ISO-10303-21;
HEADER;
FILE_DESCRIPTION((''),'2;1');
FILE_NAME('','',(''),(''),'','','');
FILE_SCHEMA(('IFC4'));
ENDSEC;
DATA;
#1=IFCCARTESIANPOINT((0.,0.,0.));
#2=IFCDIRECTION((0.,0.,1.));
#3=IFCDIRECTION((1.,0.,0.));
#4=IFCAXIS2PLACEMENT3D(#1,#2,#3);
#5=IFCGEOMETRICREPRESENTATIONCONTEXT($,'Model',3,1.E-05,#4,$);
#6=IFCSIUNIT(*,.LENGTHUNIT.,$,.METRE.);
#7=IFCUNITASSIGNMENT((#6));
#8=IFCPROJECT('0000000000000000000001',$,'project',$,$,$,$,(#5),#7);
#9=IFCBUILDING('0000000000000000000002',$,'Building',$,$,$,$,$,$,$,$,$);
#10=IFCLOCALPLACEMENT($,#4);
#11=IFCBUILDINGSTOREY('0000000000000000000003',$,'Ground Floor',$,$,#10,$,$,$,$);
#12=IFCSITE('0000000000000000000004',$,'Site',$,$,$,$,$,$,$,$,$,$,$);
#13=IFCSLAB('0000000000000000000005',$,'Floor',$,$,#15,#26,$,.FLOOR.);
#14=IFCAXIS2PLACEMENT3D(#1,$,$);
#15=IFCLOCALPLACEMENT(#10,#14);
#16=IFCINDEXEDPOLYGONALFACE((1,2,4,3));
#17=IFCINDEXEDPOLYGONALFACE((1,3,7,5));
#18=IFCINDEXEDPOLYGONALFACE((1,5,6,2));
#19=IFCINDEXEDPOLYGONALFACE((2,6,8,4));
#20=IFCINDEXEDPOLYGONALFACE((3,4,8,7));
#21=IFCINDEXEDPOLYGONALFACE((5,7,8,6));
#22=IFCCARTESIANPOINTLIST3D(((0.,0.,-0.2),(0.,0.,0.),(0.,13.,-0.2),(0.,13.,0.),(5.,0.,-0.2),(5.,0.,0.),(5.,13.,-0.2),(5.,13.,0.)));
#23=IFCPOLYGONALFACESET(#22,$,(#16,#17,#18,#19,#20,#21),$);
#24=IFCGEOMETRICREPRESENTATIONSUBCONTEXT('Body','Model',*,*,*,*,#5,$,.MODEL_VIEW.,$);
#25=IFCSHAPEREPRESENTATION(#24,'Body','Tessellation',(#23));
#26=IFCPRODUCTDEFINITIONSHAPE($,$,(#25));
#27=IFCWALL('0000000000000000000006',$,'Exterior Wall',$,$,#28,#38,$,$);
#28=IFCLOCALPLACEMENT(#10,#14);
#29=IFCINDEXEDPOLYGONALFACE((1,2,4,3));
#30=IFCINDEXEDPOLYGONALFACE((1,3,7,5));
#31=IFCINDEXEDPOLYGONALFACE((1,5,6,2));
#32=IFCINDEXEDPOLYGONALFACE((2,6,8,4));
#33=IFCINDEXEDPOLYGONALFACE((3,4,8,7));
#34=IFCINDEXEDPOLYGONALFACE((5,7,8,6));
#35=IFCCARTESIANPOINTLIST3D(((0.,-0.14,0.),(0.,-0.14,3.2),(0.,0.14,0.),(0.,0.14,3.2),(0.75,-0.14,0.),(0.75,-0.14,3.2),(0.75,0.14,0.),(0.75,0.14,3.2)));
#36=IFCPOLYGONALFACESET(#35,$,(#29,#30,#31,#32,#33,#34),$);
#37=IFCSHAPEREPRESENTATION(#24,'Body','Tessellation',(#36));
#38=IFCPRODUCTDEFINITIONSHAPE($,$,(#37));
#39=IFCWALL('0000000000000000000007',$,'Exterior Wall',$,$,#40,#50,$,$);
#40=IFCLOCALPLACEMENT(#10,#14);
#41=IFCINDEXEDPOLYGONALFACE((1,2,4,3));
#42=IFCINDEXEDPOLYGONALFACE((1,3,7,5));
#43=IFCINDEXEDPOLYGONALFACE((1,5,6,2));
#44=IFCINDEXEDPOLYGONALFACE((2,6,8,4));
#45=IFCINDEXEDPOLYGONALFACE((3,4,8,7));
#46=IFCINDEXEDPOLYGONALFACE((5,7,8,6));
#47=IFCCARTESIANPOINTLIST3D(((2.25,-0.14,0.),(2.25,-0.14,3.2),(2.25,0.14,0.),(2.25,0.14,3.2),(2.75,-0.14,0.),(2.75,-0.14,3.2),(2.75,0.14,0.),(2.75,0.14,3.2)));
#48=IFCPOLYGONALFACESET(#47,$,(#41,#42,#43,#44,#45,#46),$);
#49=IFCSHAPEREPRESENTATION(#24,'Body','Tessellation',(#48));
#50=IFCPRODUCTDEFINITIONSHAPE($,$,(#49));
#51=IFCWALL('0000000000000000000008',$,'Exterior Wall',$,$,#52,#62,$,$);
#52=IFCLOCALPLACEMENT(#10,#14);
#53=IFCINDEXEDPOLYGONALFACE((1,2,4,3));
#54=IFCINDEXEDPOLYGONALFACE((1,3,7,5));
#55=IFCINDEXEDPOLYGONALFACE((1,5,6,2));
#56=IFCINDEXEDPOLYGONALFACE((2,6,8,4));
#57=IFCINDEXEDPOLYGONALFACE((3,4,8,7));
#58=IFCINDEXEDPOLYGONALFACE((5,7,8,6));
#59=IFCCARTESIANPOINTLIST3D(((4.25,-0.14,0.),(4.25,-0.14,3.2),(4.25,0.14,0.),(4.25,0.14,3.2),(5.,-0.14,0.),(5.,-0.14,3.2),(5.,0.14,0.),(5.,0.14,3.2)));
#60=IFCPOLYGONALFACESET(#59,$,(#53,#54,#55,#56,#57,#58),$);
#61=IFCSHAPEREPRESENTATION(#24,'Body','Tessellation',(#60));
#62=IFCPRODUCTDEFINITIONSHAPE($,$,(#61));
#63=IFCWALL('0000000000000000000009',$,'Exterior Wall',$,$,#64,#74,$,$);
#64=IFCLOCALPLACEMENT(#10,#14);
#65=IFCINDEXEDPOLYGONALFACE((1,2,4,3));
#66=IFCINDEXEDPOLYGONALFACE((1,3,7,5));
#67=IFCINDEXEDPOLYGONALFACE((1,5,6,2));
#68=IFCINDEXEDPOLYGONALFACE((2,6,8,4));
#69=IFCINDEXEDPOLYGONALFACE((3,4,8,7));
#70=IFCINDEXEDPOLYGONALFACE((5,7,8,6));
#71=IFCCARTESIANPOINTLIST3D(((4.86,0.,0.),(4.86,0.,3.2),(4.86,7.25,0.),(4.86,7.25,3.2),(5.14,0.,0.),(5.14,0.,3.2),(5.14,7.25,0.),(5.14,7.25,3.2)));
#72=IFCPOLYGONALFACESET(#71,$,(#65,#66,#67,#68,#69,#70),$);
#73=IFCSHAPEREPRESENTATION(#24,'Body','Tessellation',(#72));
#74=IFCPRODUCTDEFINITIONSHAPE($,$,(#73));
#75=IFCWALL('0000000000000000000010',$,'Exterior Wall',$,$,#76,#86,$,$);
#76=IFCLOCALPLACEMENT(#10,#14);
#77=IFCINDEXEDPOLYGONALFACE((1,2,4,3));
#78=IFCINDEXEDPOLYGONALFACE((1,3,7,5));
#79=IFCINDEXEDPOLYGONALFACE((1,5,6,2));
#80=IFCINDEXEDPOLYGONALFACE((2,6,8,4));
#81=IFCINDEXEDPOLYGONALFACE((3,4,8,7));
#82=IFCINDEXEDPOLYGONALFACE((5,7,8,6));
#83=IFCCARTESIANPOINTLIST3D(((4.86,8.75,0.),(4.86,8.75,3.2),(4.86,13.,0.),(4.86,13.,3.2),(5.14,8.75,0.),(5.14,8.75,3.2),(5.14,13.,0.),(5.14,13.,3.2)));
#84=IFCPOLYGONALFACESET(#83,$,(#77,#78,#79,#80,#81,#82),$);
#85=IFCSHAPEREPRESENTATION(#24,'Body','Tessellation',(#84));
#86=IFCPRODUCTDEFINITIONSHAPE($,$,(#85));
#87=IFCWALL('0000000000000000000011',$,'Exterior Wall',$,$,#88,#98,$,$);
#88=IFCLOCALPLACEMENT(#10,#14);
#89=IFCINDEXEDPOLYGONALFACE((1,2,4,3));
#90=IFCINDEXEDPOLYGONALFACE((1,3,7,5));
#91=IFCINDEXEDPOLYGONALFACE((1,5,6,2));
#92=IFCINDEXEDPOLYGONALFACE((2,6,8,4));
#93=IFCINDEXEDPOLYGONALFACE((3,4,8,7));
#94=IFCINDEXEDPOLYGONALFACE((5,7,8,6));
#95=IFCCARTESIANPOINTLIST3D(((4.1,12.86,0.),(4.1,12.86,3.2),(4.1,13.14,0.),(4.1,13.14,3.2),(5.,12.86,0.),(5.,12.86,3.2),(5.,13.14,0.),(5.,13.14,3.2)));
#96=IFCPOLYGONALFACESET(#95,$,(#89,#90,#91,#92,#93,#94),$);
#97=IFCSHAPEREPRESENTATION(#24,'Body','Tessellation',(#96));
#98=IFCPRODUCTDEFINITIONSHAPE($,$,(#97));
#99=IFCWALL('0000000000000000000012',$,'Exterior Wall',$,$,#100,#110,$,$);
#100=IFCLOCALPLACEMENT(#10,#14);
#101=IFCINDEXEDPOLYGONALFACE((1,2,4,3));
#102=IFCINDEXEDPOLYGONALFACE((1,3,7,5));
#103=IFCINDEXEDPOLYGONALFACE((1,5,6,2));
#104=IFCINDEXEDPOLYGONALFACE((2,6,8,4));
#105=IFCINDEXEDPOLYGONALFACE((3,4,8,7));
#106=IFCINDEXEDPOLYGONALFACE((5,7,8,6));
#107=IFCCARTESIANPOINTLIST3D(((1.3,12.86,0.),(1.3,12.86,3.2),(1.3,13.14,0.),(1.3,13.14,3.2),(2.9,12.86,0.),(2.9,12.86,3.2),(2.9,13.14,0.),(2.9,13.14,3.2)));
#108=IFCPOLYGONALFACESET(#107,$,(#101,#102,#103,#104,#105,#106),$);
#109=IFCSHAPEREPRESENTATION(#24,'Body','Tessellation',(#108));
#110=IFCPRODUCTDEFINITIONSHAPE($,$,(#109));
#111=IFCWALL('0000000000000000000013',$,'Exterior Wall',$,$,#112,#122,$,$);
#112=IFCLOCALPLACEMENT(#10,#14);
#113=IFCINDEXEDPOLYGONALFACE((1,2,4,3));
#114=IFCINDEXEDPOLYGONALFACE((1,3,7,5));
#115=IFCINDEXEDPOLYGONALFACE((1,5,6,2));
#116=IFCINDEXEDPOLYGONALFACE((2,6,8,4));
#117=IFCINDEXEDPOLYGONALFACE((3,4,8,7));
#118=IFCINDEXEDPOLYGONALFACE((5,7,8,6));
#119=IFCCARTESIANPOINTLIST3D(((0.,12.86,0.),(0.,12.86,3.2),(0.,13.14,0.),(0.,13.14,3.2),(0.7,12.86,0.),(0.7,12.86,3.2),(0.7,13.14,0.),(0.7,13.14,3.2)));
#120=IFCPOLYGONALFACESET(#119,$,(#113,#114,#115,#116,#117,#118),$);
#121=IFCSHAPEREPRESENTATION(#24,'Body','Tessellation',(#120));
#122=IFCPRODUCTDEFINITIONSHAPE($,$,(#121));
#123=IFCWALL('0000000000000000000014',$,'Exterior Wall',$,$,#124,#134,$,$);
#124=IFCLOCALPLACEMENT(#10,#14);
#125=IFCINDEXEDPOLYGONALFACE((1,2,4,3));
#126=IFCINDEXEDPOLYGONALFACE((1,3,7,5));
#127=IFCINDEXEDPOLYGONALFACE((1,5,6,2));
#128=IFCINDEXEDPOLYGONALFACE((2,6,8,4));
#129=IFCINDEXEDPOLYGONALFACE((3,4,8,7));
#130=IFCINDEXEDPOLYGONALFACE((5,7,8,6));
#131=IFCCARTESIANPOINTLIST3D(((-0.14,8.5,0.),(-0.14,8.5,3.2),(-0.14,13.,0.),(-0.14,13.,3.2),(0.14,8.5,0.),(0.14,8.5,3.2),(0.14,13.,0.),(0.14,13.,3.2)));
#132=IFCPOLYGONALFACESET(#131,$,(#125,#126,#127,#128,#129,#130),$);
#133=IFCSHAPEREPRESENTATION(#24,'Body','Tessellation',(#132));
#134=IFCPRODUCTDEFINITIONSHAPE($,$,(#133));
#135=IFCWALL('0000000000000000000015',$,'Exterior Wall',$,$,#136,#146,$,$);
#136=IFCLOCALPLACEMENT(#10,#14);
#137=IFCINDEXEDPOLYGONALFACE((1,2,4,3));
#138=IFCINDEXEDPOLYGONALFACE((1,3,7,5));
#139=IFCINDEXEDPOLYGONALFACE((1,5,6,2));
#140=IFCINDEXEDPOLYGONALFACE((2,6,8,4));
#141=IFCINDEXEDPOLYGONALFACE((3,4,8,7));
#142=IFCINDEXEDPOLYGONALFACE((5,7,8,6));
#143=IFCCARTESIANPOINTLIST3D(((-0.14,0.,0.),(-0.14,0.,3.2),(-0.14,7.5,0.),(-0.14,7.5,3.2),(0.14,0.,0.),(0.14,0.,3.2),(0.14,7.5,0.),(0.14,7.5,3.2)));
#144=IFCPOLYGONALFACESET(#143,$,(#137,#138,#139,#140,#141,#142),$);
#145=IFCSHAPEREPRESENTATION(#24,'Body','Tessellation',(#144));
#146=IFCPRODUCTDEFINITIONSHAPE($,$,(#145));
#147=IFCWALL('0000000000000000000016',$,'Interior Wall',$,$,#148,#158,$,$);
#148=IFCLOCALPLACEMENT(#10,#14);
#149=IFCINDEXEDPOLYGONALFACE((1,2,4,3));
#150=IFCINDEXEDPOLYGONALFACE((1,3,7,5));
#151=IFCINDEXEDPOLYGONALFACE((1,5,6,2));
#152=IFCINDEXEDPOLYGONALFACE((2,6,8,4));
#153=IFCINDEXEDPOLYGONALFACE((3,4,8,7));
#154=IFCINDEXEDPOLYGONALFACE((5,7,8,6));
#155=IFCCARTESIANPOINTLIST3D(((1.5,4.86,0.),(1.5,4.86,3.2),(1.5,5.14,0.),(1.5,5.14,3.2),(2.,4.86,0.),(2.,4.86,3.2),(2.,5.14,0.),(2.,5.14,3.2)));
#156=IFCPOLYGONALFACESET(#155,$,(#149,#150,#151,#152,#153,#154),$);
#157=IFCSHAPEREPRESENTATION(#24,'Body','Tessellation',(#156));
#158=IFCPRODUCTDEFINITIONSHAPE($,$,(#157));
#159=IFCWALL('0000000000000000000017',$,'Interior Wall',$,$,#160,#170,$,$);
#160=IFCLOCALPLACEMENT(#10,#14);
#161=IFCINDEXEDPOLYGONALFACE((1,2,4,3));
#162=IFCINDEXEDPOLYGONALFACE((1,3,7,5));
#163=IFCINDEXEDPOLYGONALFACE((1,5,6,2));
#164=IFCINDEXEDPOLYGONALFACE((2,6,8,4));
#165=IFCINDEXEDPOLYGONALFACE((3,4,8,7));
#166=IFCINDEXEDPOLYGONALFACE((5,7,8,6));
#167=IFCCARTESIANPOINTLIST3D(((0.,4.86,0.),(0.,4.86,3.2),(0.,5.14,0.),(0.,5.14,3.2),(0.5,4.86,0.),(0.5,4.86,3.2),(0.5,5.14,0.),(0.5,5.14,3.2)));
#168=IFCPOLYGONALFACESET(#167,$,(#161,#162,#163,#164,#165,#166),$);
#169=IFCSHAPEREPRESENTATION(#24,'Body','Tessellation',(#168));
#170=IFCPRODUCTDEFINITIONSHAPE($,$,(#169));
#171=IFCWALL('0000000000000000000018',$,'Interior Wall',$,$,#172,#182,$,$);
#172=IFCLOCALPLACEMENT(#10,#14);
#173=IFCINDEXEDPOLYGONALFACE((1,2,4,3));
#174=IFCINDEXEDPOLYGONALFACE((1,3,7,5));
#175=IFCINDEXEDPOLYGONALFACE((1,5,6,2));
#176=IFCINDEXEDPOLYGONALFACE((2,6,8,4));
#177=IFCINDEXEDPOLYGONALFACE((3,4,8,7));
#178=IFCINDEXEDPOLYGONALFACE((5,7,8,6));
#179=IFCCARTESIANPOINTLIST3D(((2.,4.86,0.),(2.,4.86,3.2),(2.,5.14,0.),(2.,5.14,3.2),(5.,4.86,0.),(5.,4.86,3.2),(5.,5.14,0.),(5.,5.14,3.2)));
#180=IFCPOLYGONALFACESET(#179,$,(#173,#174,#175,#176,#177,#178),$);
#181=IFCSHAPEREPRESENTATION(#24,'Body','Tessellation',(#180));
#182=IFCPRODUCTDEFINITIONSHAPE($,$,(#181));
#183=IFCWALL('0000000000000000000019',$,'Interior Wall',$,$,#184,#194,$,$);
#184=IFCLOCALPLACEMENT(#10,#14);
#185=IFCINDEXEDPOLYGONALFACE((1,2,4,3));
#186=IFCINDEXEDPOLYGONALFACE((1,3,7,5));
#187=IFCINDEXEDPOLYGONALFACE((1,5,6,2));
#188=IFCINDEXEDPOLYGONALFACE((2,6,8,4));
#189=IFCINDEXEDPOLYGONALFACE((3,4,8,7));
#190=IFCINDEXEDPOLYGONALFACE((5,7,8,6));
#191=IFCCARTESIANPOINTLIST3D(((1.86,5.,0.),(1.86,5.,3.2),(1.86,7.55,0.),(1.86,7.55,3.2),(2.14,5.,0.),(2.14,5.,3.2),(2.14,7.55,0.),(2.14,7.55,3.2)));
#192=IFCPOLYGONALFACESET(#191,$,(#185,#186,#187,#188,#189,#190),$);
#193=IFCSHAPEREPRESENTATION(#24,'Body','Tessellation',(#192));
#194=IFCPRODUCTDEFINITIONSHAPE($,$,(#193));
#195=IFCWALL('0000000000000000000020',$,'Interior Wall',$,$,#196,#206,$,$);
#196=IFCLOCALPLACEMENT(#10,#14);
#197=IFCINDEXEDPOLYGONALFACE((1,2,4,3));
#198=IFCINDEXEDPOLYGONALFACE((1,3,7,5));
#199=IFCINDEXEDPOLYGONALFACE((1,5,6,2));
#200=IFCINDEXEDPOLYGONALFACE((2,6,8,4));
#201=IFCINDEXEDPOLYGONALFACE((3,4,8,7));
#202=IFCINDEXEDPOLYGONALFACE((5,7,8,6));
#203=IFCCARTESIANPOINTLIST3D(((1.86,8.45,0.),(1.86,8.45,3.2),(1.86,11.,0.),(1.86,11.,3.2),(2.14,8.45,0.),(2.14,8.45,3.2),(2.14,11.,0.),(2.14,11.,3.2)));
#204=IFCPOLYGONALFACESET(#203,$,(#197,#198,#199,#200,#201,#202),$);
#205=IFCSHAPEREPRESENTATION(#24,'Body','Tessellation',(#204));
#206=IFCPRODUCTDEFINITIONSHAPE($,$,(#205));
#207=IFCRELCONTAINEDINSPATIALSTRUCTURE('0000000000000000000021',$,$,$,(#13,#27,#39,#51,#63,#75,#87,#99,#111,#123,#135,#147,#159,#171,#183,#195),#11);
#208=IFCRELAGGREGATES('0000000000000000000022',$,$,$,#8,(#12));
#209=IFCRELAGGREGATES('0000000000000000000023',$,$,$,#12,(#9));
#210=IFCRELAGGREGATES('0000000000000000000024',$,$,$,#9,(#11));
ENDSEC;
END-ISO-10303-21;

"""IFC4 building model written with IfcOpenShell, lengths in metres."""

from ifc_helpers import new_model, si_unit, frame, origin_with_axes, place, context, subcontext, project, spatial, indexed_curve, outline, extrude, element, save


model = new_model("IFC4")

# Units and contexts
model_context = context("Model", 3, precision=1e-05, world=origin_with_axes())
body_context = subcontext(model_context, "Body", "Model", "MODEL_VIEW")
ifc_project = project(units=[si_unit("LENGTHUNIT", "METRE")], contexts=[model_context])

# Site, building, storey
site = spatial("IfcSite", under=ifc_project, Name="Site")
building = spatial("IfcBuilding", under=site, Name="Building")
storey_placement = place(None, origin_with_axes())
storey = spatial("IfcBuildingStorey", under=building, at=storey_placement, Name="Ground Floor")

# Slab
slab_placement = place(storey_placement, frame((0.0, 0.0, -0.2), z_axis=(0.0, 0.0, 1.0), x_axis=(1.0, 0.0, 0.0)))
element("IfcSlab", 1, at=slab_placement, inside=storey, Name="Floor", PredefinedType="FLOOR", context=body_context, shape_type="SweptSolid", body=[
    extrude(outline(indexed_curve([(0.0, 0.0), (5.0, 0.0), (5.0, 13.0), (0.0, 13.0)])), None, (0.0, 0.0, 1.0), 0.2),
])

# Walls
wall_1_placement = place(storey_placement, origin_with_axes())
element("IfcWall", 2, at=wall_1_placement, inside=storey, Name="Exterior Wall", context=body_context, shape_type="SweptSolid", body=[
    extrude(outline(indexed_curve([(0.0, 0.0), (0.0, 0.28), (0.75, 0.28), (0.75, 0.0), (0.0, 0.0)], self_intersect=False)), frame((0.0, -0.14, 0.0), z_axis=(0.0, 0.0, 1.0), x_axis=(1.0, 0.0, 0.0)), (0.0, 0.0, 1.0), 3.2),
])
wall_2_placement = place(storey_placement, frame((2.25, 0.0, 0.0), z_axis=(0.0, 0.0, 1.0), x_axis=(1.0, 0.0, 0.0)))
element("IfcWall", 3, at=wall_2_placement, inside=storey, Name="Exterior Wall", context=body_context, shape_type="SweptSolid", body=[
    extrude(outline(indexed_curve([(0.0, 0.0), (0.0, 0.28), (0.5, 0.28), (0.5, 0.0), (0.0, 0.0)], self_intersect=False)), frame((0.0, -0.14, 0.0), z_axis=(0.0, 0.0, 1.0), x_axis=(1.0, 0.0, 0.0)), (0.0, 0.0, 1.0), 3.2),
])
wall_3_placement = place(storey_placement, frame((4.25, 0.0, 0.0), z_axis=(0.0, 0.0, 1.0), x_axis=(1.0, 0.0, 0.0)))
element("IfcWall", 4, at=wall_3_placement, inside=storey, Name="Exterior Wall", context=body_context, shape_type="SweptSolid", body=[
    extrude(outline(indexed_curve([(0.0, 0.0), (0.0, 0.28), (0.75, 0.28), (0.75, 0.0), (0.0, 0.0)], self_intersect=False)), frame((0.0, -0.14, 0.0), z_axis=(0.0, 0.0, 1.0), x_axis=(1.0, 0.0, 0.0)), (0.0, 0.0, 1.0), 3.2),
])
wall_4_placement = place(storey_placement, frame((5.0, 0.0, 0.0), z_axis=(0.0, 0.0, 1.0), x_axis=(0.0, 1.0, 0.0)))
element("IfcWall", 5, at=wall_4_placement, inside=storey, Name="Exterior Wall", context=body_context, shape_type="SweptSolid", body=[
    extrude(outline(indexed_curve([(0.0, 0.0), (0.0, 0.28), (7.25, 0.28), (7.25, 0.0), (0.0, 0.0)], self_intersect=False)), frame((0.0, -0.14, 0.0), z_axis=(0.0, 0.0, 1.0), x_axis=(1.0, 0.0, 0.0)), (0.0, 0.0, 1.0), 3.2),
])
wall_5_placement = place(storey_placement, frame((5.0, 8.75, 0.0), z_axis=(0.0, 0.0, 1.0), x_axis=(0.0, 1.0, 0.0)))
element("IfcWall", 6, at=wall_5_placement, inside=storey, Name="Exterior Wall", context=body_context, shape_type="SweptSolid", body=[
    extrude(outline(indexed_curve([(0.0, 0.0), (0.0, 0.28), (4.25, 0.28), (4.25, 0.0), (0.0, 0.0)], self_intersect=False)), frame((0.0, -0.14, 0.0), z_axis=(0.0, 0.0, 1.0), x_axis=(1.0, 0.0, 0.0)), (0.0, 0.0, 1.0), 3.2),
])
wall_6_placement = place(storey_placement, frame((5.0, 13.0, 0.0), z_axis=(0.0, 0.0, 1.0), x_axis=(-1.0, 0.0, 0.0)))
element("IfcWall", 7, at=wall_6_placement, inside=storey, Name="Exterior Wall", context=body_context, shape_type="SweptSolid", body=[
    extrude(outline(indexed_curve([(0.0, 0.0), (0.0, 0.28), (0.9, 0.28), (0.9, 0.0), (0.0, 0.0)], self_intersect=False)), frame((0.0, -0.14, 0.0), z_axis=(0.0, 0.0, 1.0), x_axis=(1.0, 0.0, 0.0)), (0.0, 0.0, 1.0), 3.2),
])
wall_7_placement = place(storey_placement, frame((2.9, 13.0, 0.0), z_axis=(0.0, 0.0, 1.0), x_axis=(-1.0, 0.0, 0.0)))
element("IfcWall", 8, at=wall_7_placement, inside=storey, Name="Exterior Wall", context=body_context, shape_type="SweptSolid", body=[
    extrude(outline(indexed_curve([(0.0, 0.0), (0.0, 0.28), (1.6, 0.28), (1.6, 0.0), (0.0, 0.0)], self_intersect=False)), frame((0.0, -0.14, 0.0), z_axis=(0.0, 0.0, 1.0), x_axis=(1.0, 0.0, 0.0)), (0.0, 0.0, 1.0), 3.2),
])
wall_8_placement = place(storey_placement, frame((0.7, 13.0, 0.0), z_axis=(0.0, 0.0, 1.0), x_axis=(-1.0, 0.0, 0.0)))
element("IfcWall", 9, at=wall_8_placement, inside=storey, Name="Exterior Wall", context=body_context, shape_type="SweptSolid", body=[
    extrude(outline(indexed_curve([(0.0, 0.0), (0.0, 0.28), (0.7, 0.28), (0.7, 0.0), (0.0, 0.0)], self_intersect=False)), frame((0.0, -0.14, 0.0), z_axis=(0.0, 0.0, 1.0), x_axis=(1.0, 0.0, 0.0)), (0.0, 0.0, 1.0), 3.2),
])
wall_9_placement = place(storey_placement, frame((0.0, 13.0, 0.0), z_axis=(0.0, 0.0, 1.0), x_axis=(0.0, -1.0, 0.0)))
element("IfcWall", 10, at=wall_9_placement, inside=storey, Name="Exterior Wall", context=body_context, shape_type="SweptSolid", body=[
    extrude(outline(indexed_curve([(0.0, 0.0), (0.0, 0.28), (4.5, 0.28), (4.5, 0.0), (0.0, 0.0)], self_intersect=False)), frame((0.0, -0.14, 0.0), z_axis=(0.0, 0.0, 1.0), x_axis=(1.0, 0.0, 0.0)), (0.0, 0.0, 1.0), 3.2),
])
wall_10_placement = place(storey_placement, frame((0.0, 7.5, 0.0), z_axis=(0.0, 0.0, 1.0), x_axis=(0.0, -1.0, 0.0)))
element("IfcWall", 11, at=wall_10_placement, inside=storey, Name="Exterior Wall", context=body_context, shape_type="SweptSolid", body=[
    extrude(outline(indexed_curve([(0.0, 0.0), (0.0, 0.28), (7.5, 0.28), (7.5, 0.0), (0.0, 0.0)], self_intersect=False)), frame((0.0, -0.14, 0.0), z_axis=(0.0, 0.0, 1.0), x_axis=(1.0, 0.0, 0.0)), (0.0, 0.0, 1.0), 3.2),
])
for number, where, z_axis, x_axis, name in (
    (12, (2.0, 5.0, 0.0), (0.0, 0.0, 1.0), (-1.0, 0.0, 0.0), "Interior Wall"),
    (13, (0.5, 5.0, 0.0), (0.0, 0.0, 1.0), (-1.0, 0.0, 0.0), "Interior Wall"),
):
    element("IfcWall", number, at=place(storey_placement, frame(where, z_axis=z_axis, x_axis=x_axis)), inside=storey, Name=name, context=body_context, shape_type="SweptSolid", body=[
        extrude(outline(indexed_curve([(0.0, 0.0), (0.0, 0.28), (0.5, 0.28), (0.5, 0.0), (0.0, 0.0)], self_intersect=False)), frame((0.0, -0.14, 0.0), z_axis=(0.0, 0.0, 1.0), x_axis=(1.0, 0.0, 0.0)), (0.0, 0.0, 1.0), 3.2),
    ])
wall_11_placement = place(storey_placement, frame((5.0, 5.0, 0.0), z_axis=(0.0, 0.0, 1.0), x_axis=(-1.0, 0.0, 0.0)))
element("IfcWall", 14, at=wall_11_placement, inside=storey, Name="Interior Wall", context=body_context, shape_type="SweptSolid", body=[
    extrude(outline(indexed_curve([(0.0, 0.0), (0.0, 0.28), (3.0, 0.28), (3.0, 0.0), (0.0, 0.0)], self_intersect=False)), frame((0.0, -0.14, 0.0), z_axis=(0.0, 0.0, 1.0), x_axis=(1.0, 0.0, 0.0)), (0.0, 0.0, 1.0), 3.2),
])
wall_12_placement = place(storey_placement, frame((2.0, 5.0, 0.0), z_axis=(0.0, 0.0, 1.0), x_axis=(0.0, 1.0, 0.0)))
element("IfcWall", 15, at=wall_12_placement, inside=storey, Name="Interior Wall", context=body_context, shape_type="SweptSolid", body=[
    extrude(outline(indexed_curve([(0.0, 0.0), (0.0, 0.28), (2.55, 0.28), (2.55, 0.0), (0.0, 0.0)], self_intersect=False)), frame((0.0, -0.14, 0.0), z_axis=(0.0, 0.0, 1.0), x_axis=(1.0, 0.0, 0.0)), (0.0, 0.0, 1.0), 3.2),
])
wall_13_placement = place(storey_placement, frame((2.0, 8.45, 0.0), z_axis=(0.0, 0.0, 1.0), x_axis=(0.0, 1.0, 0.0)))
element("IfcWall", 16, at=wall_13_placement, inside=storey, Name="Interior Wall", context=body_context, shape_type="SweptSolid", body=[
    extrude(outline(indexed_curve([(0.0, 0.0), (0.0, 0.28), (2.55, 0.28), (2.55, 0.0), (0.0, 0.0)], self_intersect=False)), frame((0.0, -0.14, 0.0), z_axis=(0.0, 0.0, 1.0), x_axis=(1.0, 0.0, 0.0)), (0.0, 0.0, 1.0), 3.2),
])

save(model, "model.ifc")
